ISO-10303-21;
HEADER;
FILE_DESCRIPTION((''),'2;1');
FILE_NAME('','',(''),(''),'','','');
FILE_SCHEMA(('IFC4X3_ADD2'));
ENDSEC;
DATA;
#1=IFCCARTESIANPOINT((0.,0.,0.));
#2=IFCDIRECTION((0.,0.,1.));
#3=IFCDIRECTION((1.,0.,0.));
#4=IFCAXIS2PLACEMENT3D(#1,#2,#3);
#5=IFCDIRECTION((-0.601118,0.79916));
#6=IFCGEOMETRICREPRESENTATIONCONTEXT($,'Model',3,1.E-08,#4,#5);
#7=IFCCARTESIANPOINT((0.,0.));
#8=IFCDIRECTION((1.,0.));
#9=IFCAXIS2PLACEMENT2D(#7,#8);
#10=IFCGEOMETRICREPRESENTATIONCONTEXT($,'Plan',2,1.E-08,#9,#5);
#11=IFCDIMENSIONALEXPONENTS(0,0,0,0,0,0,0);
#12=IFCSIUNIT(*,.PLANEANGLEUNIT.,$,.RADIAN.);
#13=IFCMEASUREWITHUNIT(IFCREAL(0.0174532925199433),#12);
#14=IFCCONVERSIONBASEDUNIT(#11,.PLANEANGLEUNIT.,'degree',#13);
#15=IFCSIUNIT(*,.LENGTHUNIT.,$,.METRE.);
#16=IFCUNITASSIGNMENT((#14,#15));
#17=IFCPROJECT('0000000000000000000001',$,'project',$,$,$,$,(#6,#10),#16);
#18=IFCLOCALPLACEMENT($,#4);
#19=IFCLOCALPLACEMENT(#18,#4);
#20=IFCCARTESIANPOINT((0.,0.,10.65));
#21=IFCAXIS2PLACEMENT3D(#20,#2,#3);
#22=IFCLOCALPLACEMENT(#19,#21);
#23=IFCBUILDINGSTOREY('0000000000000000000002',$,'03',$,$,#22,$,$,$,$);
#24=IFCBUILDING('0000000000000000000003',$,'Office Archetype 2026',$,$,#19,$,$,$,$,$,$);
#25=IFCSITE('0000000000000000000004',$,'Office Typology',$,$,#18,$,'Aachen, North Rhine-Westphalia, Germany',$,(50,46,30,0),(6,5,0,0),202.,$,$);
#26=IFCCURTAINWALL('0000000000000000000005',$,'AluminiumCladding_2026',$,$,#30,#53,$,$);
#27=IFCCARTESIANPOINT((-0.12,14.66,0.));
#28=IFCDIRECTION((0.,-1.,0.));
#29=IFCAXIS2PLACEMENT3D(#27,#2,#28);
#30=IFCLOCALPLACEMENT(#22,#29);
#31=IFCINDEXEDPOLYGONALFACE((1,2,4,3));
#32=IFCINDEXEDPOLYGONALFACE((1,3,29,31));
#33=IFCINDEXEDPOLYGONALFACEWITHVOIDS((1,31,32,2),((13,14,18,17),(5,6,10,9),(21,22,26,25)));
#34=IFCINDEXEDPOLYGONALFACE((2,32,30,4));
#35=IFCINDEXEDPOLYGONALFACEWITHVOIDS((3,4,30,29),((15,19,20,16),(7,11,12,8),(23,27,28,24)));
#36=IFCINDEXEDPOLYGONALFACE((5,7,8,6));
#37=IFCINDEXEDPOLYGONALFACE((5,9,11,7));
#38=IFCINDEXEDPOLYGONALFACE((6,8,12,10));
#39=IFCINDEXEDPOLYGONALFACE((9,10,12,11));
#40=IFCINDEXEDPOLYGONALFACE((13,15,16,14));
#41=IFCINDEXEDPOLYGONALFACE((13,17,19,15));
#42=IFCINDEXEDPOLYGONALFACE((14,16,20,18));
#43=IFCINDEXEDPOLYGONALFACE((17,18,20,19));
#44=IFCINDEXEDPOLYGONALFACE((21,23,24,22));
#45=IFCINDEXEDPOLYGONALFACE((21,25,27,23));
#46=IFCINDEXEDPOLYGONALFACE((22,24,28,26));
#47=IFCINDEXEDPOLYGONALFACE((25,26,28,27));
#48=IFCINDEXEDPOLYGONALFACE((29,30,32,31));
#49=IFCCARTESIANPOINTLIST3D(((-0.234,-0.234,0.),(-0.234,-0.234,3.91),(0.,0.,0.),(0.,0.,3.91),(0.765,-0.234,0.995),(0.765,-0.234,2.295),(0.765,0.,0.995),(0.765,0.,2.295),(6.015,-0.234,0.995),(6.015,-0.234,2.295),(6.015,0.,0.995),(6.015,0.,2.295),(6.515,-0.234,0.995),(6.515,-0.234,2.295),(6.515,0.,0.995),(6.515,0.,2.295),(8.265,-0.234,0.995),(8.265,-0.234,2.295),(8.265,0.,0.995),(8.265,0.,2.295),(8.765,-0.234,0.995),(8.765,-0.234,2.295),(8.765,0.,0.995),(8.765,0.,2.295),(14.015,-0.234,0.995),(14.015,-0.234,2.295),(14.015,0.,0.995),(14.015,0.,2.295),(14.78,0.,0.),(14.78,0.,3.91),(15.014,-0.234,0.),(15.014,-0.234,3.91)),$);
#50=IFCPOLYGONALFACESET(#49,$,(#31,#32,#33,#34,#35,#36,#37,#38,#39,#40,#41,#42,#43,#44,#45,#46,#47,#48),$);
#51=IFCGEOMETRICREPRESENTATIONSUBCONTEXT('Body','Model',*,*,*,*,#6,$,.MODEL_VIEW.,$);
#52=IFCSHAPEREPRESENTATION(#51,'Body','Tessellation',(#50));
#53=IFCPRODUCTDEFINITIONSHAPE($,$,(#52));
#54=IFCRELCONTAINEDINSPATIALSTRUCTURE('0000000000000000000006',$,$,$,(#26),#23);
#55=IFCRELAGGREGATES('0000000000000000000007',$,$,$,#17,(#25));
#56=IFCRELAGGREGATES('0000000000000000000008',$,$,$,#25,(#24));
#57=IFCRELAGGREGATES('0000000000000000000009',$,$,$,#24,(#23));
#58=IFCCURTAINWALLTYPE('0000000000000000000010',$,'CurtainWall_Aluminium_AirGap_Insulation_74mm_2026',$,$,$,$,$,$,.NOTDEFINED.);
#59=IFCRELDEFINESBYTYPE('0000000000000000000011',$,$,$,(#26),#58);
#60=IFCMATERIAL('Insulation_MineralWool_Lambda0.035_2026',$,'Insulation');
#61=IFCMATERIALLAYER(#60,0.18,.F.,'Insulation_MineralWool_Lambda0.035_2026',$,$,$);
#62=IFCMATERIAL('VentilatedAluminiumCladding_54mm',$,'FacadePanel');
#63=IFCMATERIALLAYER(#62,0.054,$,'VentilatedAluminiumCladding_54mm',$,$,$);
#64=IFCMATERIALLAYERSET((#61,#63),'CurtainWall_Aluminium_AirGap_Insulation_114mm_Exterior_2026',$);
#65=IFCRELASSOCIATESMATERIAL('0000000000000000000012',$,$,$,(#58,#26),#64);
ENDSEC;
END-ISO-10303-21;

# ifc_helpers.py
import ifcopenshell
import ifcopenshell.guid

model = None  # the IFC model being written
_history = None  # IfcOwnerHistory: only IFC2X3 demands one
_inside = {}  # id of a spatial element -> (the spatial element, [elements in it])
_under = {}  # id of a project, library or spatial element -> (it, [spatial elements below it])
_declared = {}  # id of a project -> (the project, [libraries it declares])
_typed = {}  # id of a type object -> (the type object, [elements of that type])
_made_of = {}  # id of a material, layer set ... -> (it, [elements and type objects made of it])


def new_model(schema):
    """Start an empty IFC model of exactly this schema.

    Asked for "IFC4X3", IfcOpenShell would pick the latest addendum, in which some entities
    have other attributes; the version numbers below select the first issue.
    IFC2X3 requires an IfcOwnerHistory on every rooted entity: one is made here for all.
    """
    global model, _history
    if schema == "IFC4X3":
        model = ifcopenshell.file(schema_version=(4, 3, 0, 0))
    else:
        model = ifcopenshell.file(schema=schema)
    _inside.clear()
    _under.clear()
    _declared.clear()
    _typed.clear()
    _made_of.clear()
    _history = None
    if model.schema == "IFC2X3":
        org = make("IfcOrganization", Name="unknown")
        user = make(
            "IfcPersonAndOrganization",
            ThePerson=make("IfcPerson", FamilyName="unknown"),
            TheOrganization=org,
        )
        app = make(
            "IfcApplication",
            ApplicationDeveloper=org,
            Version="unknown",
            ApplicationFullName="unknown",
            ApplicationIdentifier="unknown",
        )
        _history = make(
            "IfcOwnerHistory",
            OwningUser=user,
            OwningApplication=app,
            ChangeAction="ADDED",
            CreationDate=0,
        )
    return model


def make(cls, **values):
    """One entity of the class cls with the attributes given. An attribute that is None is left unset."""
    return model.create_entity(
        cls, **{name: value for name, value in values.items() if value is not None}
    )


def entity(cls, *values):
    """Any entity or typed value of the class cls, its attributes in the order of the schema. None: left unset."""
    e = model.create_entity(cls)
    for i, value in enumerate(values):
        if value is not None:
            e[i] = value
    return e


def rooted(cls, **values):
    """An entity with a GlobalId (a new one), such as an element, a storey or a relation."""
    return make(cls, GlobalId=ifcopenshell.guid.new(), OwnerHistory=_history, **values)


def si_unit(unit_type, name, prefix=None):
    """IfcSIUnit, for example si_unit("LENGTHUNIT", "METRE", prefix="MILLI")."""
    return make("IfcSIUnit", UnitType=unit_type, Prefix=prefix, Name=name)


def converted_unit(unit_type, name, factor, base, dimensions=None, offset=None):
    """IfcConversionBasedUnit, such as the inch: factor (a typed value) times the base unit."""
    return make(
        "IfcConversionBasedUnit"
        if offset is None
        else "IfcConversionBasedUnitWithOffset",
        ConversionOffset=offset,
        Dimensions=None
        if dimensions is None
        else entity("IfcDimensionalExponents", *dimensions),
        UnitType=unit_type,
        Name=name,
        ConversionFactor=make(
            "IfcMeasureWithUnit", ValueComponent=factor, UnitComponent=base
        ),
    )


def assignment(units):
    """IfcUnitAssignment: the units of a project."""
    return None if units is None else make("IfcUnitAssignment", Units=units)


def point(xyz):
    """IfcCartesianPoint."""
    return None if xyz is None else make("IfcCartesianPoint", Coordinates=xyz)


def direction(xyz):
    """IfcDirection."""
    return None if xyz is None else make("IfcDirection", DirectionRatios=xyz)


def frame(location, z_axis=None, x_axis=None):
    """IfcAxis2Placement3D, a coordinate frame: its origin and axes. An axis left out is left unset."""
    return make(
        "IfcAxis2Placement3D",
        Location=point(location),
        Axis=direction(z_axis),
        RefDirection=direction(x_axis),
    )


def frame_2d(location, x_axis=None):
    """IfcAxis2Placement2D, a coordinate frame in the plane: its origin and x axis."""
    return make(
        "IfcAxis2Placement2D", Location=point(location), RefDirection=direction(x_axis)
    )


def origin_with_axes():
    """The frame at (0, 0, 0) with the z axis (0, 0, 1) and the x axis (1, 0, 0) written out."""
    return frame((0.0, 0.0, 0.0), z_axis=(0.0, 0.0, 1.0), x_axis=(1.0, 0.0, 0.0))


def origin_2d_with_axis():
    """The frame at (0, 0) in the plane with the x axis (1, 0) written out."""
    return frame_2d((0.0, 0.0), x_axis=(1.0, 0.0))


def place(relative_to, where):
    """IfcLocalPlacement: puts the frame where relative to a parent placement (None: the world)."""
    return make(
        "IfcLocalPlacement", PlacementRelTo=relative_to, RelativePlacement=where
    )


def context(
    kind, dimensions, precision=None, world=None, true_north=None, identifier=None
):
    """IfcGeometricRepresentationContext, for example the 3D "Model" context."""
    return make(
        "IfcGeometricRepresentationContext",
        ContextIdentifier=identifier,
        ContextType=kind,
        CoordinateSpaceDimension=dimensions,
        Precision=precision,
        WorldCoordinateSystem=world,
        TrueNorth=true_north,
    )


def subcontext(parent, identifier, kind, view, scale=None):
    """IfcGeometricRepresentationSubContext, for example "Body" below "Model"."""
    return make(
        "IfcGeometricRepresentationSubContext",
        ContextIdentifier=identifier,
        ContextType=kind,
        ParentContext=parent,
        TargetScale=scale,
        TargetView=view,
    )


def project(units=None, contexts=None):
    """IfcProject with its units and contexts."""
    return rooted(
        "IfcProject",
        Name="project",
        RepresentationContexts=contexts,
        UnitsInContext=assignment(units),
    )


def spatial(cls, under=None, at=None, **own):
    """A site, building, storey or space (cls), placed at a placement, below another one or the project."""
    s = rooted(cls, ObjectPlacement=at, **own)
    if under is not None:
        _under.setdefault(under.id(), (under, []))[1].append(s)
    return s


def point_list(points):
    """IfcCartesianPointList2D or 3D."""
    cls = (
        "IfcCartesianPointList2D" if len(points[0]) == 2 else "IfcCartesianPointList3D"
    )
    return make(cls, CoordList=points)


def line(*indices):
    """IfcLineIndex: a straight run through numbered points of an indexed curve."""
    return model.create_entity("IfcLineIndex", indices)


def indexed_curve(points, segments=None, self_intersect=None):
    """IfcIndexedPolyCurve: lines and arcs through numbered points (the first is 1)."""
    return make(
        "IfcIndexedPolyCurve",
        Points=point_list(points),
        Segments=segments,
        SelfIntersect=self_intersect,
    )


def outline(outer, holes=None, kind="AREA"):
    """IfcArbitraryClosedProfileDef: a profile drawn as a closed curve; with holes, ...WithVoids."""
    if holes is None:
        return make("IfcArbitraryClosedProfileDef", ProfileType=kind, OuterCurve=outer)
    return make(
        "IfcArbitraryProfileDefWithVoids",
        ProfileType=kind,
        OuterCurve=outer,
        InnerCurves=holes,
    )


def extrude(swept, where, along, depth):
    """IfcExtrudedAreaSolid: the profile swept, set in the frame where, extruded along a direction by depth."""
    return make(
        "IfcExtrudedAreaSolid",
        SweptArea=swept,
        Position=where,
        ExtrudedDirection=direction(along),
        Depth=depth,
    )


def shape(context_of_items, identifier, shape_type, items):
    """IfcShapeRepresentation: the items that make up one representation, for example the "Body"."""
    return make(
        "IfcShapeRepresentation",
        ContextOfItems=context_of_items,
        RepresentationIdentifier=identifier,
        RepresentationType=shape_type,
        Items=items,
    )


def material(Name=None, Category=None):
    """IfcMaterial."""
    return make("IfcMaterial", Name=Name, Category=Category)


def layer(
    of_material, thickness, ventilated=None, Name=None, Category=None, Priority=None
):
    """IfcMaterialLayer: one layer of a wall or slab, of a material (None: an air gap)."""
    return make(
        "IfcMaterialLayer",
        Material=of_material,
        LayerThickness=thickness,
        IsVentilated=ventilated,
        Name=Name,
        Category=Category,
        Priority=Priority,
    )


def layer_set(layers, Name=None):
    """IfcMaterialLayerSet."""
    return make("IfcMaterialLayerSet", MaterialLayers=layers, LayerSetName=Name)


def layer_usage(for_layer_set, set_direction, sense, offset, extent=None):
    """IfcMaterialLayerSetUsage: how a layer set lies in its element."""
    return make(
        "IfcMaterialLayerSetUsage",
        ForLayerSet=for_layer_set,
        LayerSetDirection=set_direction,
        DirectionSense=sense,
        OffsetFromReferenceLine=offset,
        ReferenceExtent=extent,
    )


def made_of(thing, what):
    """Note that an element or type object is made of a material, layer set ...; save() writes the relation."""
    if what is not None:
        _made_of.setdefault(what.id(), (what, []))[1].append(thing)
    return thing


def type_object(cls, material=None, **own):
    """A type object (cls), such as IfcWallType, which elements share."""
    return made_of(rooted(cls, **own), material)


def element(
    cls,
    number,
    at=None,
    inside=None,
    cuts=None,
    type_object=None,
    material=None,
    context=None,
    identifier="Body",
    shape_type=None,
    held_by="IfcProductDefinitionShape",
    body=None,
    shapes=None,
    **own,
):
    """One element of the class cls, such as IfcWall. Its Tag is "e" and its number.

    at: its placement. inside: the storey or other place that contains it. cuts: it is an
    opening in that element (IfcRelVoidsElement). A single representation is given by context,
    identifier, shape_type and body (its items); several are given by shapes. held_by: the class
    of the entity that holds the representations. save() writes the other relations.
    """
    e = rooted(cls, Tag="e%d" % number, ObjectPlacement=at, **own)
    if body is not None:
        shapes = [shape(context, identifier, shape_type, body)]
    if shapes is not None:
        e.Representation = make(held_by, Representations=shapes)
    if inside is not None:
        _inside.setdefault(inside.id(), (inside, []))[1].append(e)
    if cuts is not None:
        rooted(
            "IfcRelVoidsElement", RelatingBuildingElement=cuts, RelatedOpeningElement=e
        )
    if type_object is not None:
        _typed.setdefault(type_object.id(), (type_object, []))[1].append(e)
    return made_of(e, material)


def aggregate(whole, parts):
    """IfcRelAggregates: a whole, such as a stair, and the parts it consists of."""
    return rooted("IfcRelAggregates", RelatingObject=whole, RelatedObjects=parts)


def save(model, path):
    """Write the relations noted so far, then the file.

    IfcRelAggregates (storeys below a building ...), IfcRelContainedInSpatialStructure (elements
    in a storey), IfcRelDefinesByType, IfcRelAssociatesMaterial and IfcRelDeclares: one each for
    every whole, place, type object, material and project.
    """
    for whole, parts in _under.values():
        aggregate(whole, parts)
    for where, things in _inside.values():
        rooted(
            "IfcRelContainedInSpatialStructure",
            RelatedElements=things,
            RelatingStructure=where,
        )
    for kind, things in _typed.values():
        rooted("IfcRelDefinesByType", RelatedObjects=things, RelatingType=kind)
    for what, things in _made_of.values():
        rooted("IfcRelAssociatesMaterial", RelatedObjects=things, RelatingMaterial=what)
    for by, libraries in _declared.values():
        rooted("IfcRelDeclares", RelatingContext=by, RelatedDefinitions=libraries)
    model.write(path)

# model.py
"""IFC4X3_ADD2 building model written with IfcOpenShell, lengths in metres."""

from ifc_helpers import new_model, entity, si_unit, converted_unit, direction, frame, origin_with_axes, origin_2d_with_axis, place, context, subcontext, project, spatial, line, indexed_curve, outline, extrude, material, layer, layer_set, layer_usage, type_object, element, save


model = new_model("IFC4X3_ADD2")

# Units and contexts
model_context = context("Model", 3, precision=1e-08, world=origin_with_axes(), true_north=direction((-0.601118, 0.79916)))
plan_context = context("Plan", 2, precision=1e-08, world=origin_2d_with_axis(), true_north=direction((-0.601118, 0.79916)))
body_context = subcontext(model_context, "Body", "Model", "MODEL_VIEW")
ifc_project = project(units=[converted_unit("PLANEANGLEUNIT", "degree", entity("IfcReal", 0.0174532925199433), si_unit("PLANEANGLEUNIT", "RADIAN"), dimensions=[0, 0, 0, 0, 0, 0, 0]), si_unit("LENGTHUNIT", "METRE")], contexts=[model_context, plan_context])

# Site, building, storey
site_placement = place(None, origin_with_axes())
site = spatial("IfcSite", under=ifc_project, at=site_placement, Name="Office Typology", LongName="Aachen, North Rhine-Westphalia, Germany", RefLatitude=(50, 46, 30, 0), RefLongitude=(6, 5, 0, 0), RefElevation=202.0)
building_placement = place(site_placement, origin_with_axes())
building = spatial("IfcBuilding", under=site, at=building_placement, Name="Office Archetype 2026")
storey_placement = place(building_placement, frame((0.0, 0.0, 10.65), z_axis=(0.0, 0.0, 1.0), x_axis=(1.0, 0.0, 0.0)))
storey = spatial("IfcBuildingStorey", under=building, at=storey_placement, Name="03")

# Curtain wall, openings
ifc_material_1 = material(Name="Insulation_MineralWool_Lambda0.035_2026", Category="Insulation")
ifc_layer_1 = layer(ifc_material_1, 0.18, ventilated=False, Name="Insulation_MineralWool_Lambda0.035_2026")
ifc_material_2 = material(Name="VentilatedAluminiumCladding_54mm", Category="FacadePanel")
ifc_layer_2 = layer(ifc_material_2, 0.054, Name="VentilatedAluminiumCladding_54mm")
ifc_layer_set_1 = layer_set([ifc_layer_1, ifc_layer_2], Name="CurtainWall_Aluminium_AirGap_Insulation_114mm_Exterior_2026")
ifc_layer_usage_1 = layer_usage(ifc_layer_set_1, "AXIS2", "NEGATIVE", 0.0)
curtain_wall_type = type_object("IfcCurtainWallType", Name="CurtainWall_Aluminium_AirGap_Insulation_74mm_2026", PredefinedType="NOTDEFINED", material=ifc_layer_set_1)
curtain_wall_placement = place(storey_placement, frame((-0.12, 14.66, 0.0), z_axis=(0.0, 0.0, 1.0), x_axis=(0.0, -1.0, 0.0)))
curtain_wall = element("IfcCurtainWall", 1, at=curtain_wall_placement, inside=storey, type_object=curtain_wall_type, material=ifc_layer_usage_1, Name="AluminiumCladding_2026", context=body_context, shape_type="SweptSolid", body=[
    extrude(outline(indexed_curve([(-0.234, -0.234), (0.0, 0.0), (14.78, 0.0), (15.014, -0.234)], segments=[line(1, 2, 3, 4, 1)])), origin_with_axes(), (0.0, 0.0, 1.0), 3.91),
])
opening_1_placement = place(curtain_wall_placement, frame((7.015, -0.5, 0.995), z_axis=(0.0, 0.0, 1.0), x_axis=(0.0, 1.0, 0.0)))
element("IfcOpeningElement", 2, at=opening_1_placement, cuts=curtain_wall, PredefinedType="OPENING", context=body_context, shape_type="SweptSolid", body=[
    extrude(outline(indexed_curve([(0.2655, -1.25), (0.5, -1.25), (0.5, 0.5), (0.2655, 0.5), (0.2655, -1.25)])), origin_with_axes(), (0.0, 0.0, 1.0), 1.3),
])
opening_2_placement = place(curtain_wall_placement, frame((9.265, -0.5, 0.995), z_axis=(0.0, 0.0, 1.0), x_axis=(0.0, 1.0, 0.0)))
element("IfcOpeningElement", 3, at=opening_2_placement, cuts=curtain_wall, PredefinedType="OPENING", context=body_context, shape_type="SweptSolid", body=[
    extrude(outline(indexed_curve([(0.2655, -4.75), (0.5, -4.75), (0.5, 0.5), (0.2655, 0.5), (0.2655, -4.75)])), origin_with_axes(), (0.0, 0.0, 1.0), 1.3),
])
opening_3_placement = place(curtain_wall_placement, frame((1.265, -0.5, 0.995), z_axis=(0.0, 0.0, 1.0), x_axis=(0.0, 1.0, 0.0)))
element("IfcOpeningElement", 4, at=opening_3_placement, cuts=curtain_wall, PredefinedType="OPENING", context=body_context, shape_type="SweptSolid", body=[
    extrude(outline(indexed_curve([(0.2655, -4.75), (0.5, -4.75), (0.5, 0.5), (0.2655, 0.5), (0.2655, -4.75)])), origin_with_axes(), (0.0, 0.0, 1.0), 1.3),
])

save(model, "model.ifc")
